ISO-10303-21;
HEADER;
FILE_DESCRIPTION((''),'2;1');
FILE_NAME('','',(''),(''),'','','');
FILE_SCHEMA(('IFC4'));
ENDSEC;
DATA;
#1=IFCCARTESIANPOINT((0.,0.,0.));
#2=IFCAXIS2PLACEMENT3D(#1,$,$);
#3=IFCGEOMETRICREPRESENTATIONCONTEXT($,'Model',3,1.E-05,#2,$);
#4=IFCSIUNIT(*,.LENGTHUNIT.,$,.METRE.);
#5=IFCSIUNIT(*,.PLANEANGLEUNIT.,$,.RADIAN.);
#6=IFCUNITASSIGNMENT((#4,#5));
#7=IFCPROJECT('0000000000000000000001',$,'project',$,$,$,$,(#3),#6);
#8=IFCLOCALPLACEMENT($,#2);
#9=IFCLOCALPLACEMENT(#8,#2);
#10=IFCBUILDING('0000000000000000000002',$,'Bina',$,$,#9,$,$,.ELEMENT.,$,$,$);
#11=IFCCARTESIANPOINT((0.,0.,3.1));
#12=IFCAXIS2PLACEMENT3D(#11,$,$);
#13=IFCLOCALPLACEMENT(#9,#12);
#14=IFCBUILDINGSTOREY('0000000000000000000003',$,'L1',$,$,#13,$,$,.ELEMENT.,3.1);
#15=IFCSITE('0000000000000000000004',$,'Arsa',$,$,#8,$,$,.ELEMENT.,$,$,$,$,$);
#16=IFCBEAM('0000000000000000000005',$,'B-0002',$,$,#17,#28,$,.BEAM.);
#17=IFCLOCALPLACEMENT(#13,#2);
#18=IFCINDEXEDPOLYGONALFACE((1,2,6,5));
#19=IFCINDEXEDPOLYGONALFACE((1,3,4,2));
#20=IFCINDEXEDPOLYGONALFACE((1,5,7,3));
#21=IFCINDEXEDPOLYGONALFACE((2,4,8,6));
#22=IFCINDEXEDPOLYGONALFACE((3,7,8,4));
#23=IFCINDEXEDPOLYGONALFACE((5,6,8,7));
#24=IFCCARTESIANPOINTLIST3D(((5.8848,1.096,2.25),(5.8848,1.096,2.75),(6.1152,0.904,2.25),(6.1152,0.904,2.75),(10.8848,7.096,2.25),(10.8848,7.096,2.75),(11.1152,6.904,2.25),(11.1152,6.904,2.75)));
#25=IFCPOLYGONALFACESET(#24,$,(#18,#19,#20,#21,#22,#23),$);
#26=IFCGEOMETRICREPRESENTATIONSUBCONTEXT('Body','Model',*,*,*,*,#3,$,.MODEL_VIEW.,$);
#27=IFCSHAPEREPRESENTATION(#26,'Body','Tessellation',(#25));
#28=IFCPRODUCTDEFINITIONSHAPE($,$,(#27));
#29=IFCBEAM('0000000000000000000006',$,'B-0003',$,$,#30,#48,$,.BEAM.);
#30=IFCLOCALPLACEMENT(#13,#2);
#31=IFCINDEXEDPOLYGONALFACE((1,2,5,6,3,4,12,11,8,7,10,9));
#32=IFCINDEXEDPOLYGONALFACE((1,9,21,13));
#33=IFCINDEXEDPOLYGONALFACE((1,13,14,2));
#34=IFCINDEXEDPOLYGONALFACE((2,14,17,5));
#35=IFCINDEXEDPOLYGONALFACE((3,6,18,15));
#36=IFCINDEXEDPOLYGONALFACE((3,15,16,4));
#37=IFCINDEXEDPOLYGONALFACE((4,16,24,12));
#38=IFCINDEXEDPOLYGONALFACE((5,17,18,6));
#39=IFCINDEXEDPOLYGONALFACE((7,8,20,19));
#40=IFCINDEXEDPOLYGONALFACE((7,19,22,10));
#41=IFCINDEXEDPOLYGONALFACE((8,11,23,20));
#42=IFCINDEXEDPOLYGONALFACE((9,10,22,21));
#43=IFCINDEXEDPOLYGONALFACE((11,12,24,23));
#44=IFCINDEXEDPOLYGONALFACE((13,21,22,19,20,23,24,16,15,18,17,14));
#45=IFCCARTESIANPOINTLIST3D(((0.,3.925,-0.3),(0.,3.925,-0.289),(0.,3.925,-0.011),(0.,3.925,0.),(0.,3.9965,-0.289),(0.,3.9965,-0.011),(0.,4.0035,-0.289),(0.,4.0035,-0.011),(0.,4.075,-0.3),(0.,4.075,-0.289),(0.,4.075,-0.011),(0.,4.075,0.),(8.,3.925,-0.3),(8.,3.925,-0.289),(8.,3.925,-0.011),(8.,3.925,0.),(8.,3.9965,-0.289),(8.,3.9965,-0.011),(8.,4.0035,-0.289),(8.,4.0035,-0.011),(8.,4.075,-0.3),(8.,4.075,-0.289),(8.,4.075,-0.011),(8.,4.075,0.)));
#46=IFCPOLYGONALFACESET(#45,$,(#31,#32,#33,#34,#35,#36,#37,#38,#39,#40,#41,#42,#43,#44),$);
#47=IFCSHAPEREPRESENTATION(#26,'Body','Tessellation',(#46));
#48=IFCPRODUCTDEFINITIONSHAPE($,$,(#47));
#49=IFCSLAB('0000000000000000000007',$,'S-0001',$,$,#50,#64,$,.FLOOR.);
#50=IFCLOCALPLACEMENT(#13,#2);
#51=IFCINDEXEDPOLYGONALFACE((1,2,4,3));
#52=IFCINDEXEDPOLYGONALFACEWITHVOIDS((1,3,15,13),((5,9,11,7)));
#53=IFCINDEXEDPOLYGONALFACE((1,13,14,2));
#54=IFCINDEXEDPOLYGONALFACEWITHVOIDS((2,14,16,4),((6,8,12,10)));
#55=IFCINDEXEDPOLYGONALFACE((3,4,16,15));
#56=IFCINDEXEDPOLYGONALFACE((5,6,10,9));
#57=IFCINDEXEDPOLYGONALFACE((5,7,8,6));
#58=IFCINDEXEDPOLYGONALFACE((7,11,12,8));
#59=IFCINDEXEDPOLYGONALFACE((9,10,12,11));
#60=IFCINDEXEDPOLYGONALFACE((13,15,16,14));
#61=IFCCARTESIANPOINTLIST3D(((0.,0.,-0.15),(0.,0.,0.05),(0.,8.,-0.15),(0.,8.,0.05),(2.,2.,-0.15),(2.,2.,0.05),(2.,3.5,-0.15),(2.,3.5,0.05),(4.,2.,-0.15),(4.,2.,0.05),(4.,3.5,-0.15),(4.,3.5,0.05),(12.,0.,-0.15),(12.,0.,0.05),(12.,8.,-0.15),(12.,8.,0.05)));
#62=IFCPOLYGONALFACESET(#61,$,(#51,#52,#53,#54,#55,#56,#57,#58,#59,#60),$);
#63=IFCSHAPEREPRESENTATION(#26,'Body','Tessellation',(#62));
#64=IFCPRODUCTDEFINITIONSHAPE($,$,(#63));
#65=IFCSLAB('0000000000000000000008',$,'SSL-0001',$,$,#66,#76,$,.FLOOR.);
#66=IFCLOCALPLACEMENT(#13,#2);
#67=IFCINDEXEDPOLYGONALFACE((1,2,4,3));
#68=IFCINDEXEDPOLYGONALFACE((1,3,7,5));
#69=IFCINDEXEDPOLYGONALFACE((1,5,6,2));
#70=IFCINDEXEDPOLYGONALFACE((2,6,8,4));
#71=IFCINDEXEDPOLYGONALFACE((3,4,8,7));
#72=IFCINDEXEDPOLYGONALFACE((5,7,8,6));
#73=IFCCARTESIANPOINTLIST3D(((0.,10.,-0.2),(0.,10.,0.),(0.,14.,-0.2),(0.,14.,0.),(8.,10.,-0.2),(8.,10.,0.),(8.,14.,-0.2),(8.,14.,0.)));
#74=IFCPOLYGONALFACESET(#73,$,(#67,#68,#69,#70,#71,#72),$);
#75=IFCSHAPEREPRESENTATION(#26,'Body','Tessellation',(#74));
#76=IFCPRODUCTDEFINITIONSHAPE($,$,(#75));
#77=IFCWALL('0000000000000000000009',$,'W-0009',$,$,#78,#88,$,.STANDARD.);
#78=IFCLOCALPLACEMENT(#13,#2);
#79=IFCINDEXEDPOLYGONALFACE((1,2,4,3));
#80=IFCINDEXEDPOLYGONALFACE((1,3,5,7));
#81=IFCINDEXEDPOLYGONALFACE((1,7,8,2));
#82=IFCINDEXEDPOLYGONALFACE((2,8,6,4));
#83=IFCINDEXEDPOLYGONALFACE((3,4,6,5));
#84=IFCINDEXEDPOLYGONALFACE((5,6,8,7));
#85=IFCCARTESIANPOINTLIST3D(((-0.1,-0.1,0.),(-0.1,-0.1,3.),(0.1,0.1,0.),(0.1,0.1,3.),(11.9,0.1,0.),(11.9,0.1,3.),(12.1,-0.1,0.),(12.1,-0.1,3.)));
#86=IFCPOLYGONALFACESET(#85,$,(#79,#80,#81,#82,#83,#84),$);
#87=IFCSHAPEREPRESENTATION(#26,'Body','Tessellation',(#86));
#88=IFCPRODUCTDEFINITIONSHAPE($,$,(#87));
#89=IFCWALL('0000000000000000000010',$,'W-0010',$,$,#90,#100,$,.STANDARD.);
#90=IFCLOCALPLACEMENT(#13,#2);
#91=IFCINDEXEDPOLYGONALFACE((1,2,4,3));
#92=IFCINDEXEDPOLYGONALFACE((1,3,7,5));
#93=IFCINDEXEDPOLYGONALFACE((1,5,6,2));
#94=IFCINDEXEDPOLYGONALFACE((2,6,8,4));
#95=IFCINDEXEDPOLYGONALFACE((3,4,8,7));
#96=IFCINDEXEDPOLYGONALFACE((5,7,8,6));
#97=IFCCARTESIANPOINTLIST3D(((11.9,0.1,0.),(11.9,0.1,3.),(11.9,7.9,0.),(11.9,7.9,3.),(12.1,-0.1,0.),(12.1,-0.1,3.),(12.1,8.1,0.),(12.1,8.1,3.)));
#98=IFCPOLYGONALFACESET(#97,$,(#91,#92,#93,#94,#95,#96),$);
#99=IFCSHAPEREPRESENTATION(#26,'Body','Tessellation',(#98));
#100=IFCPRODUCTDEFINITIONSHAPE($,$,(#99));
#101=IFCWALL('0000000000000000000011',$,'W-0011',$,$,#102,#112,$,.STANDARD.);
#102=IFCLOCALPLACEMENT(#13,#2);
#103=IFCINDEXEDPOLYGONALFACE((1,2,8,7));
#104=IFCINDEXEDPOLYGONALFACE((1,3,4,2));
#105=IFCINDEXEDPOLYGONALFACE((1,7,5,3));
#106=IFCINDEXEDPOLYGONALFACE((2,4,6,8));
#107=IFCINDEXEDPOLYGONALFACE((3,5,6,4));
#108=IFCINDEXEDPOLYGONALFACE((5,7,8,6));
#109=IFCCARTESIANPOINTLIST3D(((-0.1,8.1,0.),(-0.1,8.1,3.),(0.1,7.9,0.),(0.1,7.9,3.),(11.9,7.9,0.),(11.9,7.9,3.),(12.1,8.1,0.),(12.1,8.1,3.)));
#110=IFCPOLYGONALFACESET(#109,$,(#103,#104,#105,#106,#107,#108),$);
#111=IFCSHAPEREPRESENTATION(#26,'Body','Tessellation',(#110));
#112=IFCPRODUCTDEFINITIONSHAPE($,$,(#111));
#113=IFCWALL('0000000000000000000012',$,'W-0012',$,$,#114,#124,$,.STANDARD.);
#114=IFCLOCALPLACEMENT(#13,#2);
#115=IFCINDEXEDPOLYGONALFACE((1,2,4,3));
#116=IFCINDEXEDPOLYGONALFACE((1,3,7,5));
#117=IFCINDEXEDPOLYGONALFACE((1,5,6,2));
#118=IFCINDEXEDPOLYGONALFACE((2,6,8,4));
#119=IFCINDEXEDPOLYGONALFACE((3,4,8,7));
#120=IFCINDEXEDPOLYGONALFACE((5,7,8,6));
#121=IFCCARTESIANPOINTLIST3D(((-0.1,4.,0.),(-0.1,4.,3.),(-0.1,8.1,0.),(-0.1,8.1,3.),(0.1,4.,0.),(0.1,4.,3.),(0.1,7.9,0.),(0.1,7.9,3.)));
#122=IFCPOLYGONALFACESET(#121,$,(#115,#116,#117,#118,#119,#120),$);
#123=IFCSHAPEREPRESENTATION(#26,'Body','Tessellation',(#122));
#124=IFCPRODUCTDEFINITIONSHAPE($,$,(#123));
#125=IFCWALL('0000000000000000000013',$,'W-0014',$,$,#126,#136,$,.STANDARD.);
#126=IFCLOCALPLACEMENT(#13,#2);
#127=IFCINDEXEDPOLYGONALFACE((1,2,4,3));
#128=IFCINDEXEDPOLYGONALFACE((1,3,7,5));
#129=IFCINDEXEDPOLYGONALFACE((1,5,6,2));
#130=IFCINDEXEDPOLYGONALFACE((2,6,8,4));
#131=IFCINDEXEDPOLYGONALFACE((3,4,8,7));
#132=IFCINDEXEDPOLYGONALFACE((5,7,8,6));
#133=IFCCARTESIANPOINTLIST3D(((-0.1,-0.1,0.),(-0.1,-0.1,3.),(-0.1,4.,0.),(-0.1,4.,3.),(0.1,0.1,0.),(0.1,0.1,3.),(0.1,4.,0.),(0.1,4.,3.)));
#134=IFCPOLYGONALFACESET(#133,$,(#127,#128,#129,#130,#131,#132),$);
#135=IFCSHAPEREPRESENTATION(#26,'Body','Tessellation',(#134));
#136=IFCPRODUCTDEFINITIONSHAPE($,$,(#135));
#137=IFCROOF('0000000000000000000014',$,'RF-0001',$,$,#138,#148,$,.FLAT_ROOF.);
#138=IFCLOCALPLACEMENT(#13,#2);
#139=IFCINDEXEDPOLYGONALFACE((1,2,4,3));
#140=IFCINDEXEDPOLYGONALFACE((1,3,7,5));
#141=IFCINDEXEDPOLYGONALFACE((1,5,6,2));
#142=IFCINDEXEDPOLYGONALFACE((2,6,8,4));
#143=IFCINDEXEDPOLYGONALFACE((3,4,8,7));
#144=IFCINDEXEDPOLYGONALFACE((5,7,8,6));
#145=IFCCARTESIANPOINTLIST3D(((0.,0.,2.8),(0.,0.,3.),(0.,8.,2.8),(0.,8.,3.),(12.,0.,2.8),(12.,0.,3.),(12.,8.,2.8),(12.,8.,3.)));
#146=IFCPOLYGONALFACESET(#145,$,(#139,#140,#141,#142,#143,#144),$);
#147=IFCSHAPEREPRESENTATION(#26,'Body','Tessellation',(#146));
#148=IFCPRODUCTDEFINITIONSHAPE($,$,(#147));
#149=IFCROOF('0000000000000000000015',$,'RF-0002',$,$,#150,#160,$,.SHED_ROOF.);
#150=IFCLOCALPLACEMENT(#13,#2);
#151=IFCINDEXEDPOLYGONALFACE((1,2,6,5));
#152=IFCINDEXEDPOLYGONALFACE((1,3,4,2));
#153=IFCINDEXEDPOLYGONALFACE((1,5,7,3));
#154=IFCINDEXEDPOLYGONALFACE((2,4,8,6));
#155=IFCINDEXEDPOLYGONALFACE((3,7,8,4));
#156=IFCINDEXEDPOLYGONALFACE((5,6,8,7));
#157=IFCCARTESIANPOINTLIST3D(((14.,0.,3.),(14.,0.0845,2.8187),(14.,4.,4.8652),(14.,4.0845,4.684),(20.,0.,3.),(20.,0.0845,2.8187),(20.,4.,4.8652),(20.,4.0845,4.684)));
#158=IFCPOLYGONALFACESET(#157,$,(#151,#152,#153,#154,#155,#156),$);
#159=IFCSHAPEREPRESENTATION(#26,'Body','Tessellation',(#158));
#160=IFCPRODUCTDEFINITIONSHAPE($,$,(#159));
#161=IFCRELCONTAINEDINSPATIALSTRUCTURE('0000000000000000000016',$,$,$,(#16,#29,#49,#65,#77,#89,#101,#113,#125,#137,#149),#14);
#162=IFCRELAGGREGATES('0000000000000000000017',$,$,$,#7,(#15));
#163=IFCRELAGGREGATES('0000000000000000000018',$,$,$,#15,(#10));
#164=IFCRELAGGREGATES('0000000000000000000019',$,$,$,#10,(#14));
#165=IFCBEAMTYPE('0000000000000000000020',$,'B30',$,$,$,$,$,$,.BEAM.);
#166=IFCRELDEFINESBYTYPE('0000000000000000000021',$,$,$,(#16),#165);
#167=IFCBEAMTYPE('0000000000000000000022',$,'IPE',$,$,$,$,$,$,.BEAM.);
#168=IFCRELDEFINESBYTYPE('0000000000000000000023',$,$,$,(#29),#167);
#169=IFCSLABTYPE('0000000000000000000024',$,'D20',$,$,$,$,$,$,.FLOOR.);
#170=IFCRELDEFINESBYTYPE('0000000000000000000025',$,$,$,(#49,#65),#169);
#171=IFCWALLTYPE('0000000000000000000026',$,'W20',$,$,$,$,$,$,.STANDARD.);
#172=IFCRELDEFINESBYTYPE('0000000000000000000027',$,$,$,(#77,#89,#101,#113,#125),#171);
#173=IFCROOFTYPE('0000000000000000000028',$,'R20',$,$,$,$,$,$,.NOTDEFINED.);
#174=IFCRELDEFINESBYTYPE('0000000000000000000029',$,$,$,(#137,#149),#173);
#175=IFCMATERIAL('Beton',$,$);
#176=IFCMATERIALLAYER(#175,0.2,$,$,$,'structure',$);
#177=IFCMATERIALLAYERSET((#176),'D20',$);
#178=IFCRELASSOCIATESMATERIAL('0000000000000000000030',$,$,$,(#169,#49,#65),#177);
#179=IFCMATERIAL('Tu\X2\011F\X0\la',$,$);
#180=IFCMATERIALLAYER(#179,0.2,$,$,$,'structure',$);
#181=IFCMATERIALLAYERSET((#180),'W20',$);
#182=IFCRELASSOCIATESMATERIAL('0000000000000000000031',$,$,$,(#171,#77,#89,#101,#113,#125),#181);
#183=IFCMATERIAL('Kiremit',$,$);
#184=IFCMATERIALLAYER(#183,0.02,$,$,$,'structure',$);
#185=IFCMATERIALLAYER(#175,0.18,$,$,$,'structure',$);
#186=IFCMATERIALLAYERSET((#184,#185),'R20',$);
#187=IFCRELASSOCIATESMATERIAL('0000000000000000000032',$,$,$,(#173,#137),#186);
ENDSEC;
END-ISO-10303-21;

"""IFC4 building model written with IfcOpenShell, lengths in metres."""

from ifc_helpers import new_model, si_unit, frame, frame_2d, origin, origin_with_axes, place, context, subcontext, project, spatial, polyline, rectangle, i_section, outline, extrude, material, layer, layer_set, layer_usage, type_object, element, save


model = new_model("IFC4")

# Units and contexts
model_context = context("Model", 3, precision=1e-05, world=origin())
body_context = subcontext(model_context, "Body", "Model", "MODEL_VIEW")
ifc_project = project(units=[si_unit("LENGTHUNIT", "METRE"), si_unit("PLANEANGLEUNIT", "RADIAN")], contexts=[model_context])

# Site, building, storey
site_placement = place(None, origin())
site = spatial("IfcSite", under=ifc_project, at=site_placement, Name="Arsa", CompositionType="ELEMENT")
building_placement = place(site_placement, origin())
building = spatial("IfcBuilding", under=site, at=building_placement, Name="Bina", CompositionType="ELEMENT")
storey_placement = place(building_placement, frame((0.0, 0.0, 3.1)))
storey = spatial("IfcBuildingStorey", under=building, at=storey_placement, Name="L1", CompositionType="ELEMENT", Elevation=3.1)

# Beams
beam_type_1 = type_object("IfcBeamType", Name="B30", PredefinedType="BEAM")
beam_1_placement = place(storey_placement, origin())
element("IfcBeam", 1, at=beam_1_placement, inside=storey, type_object=beam_type_1, Name="B-0002", PredefinedType="BEAM", context=body_context, shape_type="SweptSolid", body=[
    extrude(rectangle(XDim=0.3, YDim=0.5, at=frame_2d((0.0, -0.25))), frame((6.0, 1.0, 2.75), z_axis=(0.640184, 0.768221, 0.0), x_axis=(-0.768221, 0.640184, 0.0)), (0.0, 0.0, 1.0), 7.8102),
])
beam_type_2 = type_object("IfcBeamType", Name="IPE", PredefinedType="BEAM")
beam_2_placement = place(storey_placement, origin())
element("IfcBeam", 2, at=beam_2_placement, inside=storey, type_object=beam_type_2, Name="B-0003", PredefinedType="BEAM", context=body_context, shape_type="SweptSolid", body=[
    extrude(i_section(OverallWidth=0.15, OverallDepth=0.3, WebThickness=0.007, FlangeThickness=0.011, at=frame_2d((0.0, -0.15))), frame((0.0, 4.0, 0.0), z_axis=(1.0, 0.0, 0.0), x_axis=(0.0, 1.0, 0.0)), (0.0, 0.0, 1.0), 8.0),
])

# Slabs
ifc_material_1 = material(Name="Beton")
ifc_layer_1 = layer(ifc_material_1, 0.2, Category="structure")
ifc_layer_set_1 = layer_set([ifc_layer_1], Name="D20")
ifc_layer_usage_1 = layer_usage(ifc_layer_set_1, "AXIS3", "NEGATIVE", 0.05)
slab_type = type_object("IfcSlabType", Name="D20", PredefinedType="FLOOR", material=ifc_layer_set_1)
slab_1_placement = place(storey_placement, origin())
element("IfcSlab", 3, at=slab_1_placement, inside=storey, type_object=slab_type, material=ifc_layer_usage_1, Name="S-0001", PredefinedType="FLOOR", context=body_context, shape_type="SweptSolid", body=[
    extrude(outline(polyline([(0.0, 0.0), (12.0, 0.0), (12.0, 8.0), (0.0, 8.0), (0.0, 0.0)]), holes=[polyline([(2.0, 2.0), (4.0, 2.0), (4.0, 3.5), (2.0, 3.5), (2.0, 2.0)])]), frame((0.0, 0.0, -0.15)), (0.0, 0.0, 1.0), 0.2),
])
ifc_layer_usage_2 = layer_usage(ifc_layer_set_1, "AXIS3", "NEGATIVE", 0.0)
slab_2_placement = place(storey_placement, origin())
element("IfcSlab", 4, at=slab_2_placement, inside=storey, type_object=slab_type, material=ifc_layer_usage_2, Name="SSL-0001", PredefinedType="FLOOR", context=body_context, shape_type="SweptSolid", body=[
    extrude(outline(polyline([(0.0, 10.0), (8.0, 10.0), (8.0, 14.0), (0.0, 14.0), (0.0, 10.0)])), frame((0.0, 0.0, -0.2)), (0.0, 0.0, 1.0), 0.2),
])

# Walls
ifc_material_2 = material(Name="Tuğla")
ifc_layer_2 = layer(ifc_material_2, 0.2, Category="structure")
ifc_layer_set_2 = layer_set([ifc_layer_2], Name="W20")
ifc_layer_usage_3 = layer_usage(ifc_layer_set_2, "AXIS2", "POSITIVE", -0.1)
wall_type = type_object("IfcWallType", Name="W20", PredefinedType="STANDARD", material=ifc_layer_set_2)
wall_1_placement = place(storey_placement, origin_with_axes())
element("IfcWall", 5, at=wall_1_placement, inside=storey, type_object=wall_type, material=ifc_layer_usage_3, Name="W-0009", PredefinedType="STANDARD", context=body_context, shape_type="SweptSolid", body=[
    extrude(outline(polyline([(0.1, 0.1), (11.9, 0.1), (12.1, -0.1), (-0.1, -0.1), (0.1, 0.1)])), origin(), (0.0, 0.0, 1.0), 3.0),
])
ifc_layer_usage_4 = layer_usage(ifc_layer_set_2, "AXIS2", "POSITIVE", -0.1)
wall_2_placement = place(storey_placement, frame((12.0, 0.0, 0.0), z_axis=(0.0, 0.0, 1.0), x_axis=(0.0, 1.0, 0.0)))
element("IfcWall", 6, at=wall_2_placement, inside=storey, type_object=wall_type, material=ifc_layer_usage_4, Name="W-0010", PredefinedType="STANDARD", context=body_context, shape_type="SweptSolid", body=[
    extrude(outline(polyline([(0.1, 0.1), (7.9, 0.1), (8.1, -0.1), (-0.1, -0.1), (0.1, 0.1)])), origin(), (0.0, 0.0, 1.0), 3.0),
])
ifc_layer_usage_5 = layer_usage(ifc_layer_set_2, "AXIS2", "POSITIVE", -0.1)
wall_3_placement = place(storey_placement, frame((12.0, 8.0, 0.0), z_axis=(0.0, 0.0, 1.0), x_axis=(-1.0, 0.0, 0.0)))
element("IfcWall", 7, at=wall_3_placement, inside=storey, type_object=wall_type, material=ifc_layer_usage_5, Name="W-0011", PredefinedType="STANDARD", context=body_context, shape_type="SweptSolid", body=[
    extrude(outline(polyline([(0.1, 0.1), (11.9, 0.1), (12.1, -0.1), (-0.1, -0.1), (0.1, 0.1)])), origin(), (0.0, 0.0, 1.0), 3.0),
])
ifc_layer_usage_6 = layer_usage(ifc_layer_set_2, "AXIS2", "POSITIVE", -0.1)
wall_4_placement = place(storey_placement, frame((0.0, 8.0, 0.0), z_axis=(0.0, 0.0, 1.0), x_axis=(0.0, -1.0, 0.0)))
element("IfcWall", 8, at=wall_4_placement, inside=storey, type_object=wall_type, material=ifc_layer_usage_6, Name="W-0012", PredefinedType="STANDARD", context=body_context, shape_type="SweptSolid", body=[
    extrude(outline(polyline([(0.1, 0.1), (4.0, 0.1), (4.0, -0.1), (-0.1, -0.1), (0.1, 0.1)])), origin(), (0.0, 0.0, 1.0), 3.0),
])
ifc_layer_usage_7 = layer_usage(ifc_layer_set_2, "AXIS2", "POSITIVE", -0.1)
wall_5_placement = place(storey_placement, frame((0.0, 4.0, 0.0), z_axis=(0.0, 0.0, 1.0), x_axis=(0.0, -1.0, 0.0)))
element("IfcWall", 9, at=wall_5_placement, inside=storey, type_object=wall_type, material=ifc_layer_usage_7, Name="W-0014", PredefinedType="STANDARD", context=body_context, shape_type="SweptSolid", body=[
    extrude(outline(polyline([(0.0, 0.1), (3.9, 0.1), (4.1, -0.1), (0.0, -0.1), (0.0, 0.1)])), origin(), (0.0, 0.0, 1.0), 3.0),
])

# Roofs
ifc_material_3 = material(Name="Kiremit")
ifc_layer_3 = layer(ifc_material_3, 0.02, Category="structure")
ifc_layer_4 = layer(ifc_material_1, 0.18, Category="structure")
ifc_layer_set_3 = layer_set([ifc_layer_3, ifc_layer_4], Name="R20")
ifc_layer_usage_8 = layer_usage(ifc_layer_set_3, "AXIS3", "NEGATIVE", 3.0)
roof_type = type_object("IfcRoofType", Name="R20", PredefinedType="NOTDEFINED", material=ifc_layer_set_3)
roof_1_placement = place(storey_placement, origin())
element("IfcRoof", 10, at=roof_1_placement, inside=storey, type_object=roof_type, material=ifc_layer_usage_8, Name="RF-0001", PredefinedType="FLAT_ROOF", context=body_context, shape_type="SweptSolid", body=[
    extrude(outline(polyline([(0.0, 0.0), (12.0, 0.0), (12.0, 8.0), (0.0, 8.0), (0.0, 0.0)])), frame((0.0, 0.0, 2.8)), (0.0, 0.0, 1.0), 0.2),
])
roof_2_placement = place(storey_placement, origin())
element("IfcRoof", 11, at=roof_2_placement, inside=storey, type_object=roof_type, Name="RF-0002", PredefinedType="SHED_ROOF", context=body_context, shape_type="SweptSolid", body=[
    extrude(outline(polyline([(14.0, 0.0), (20.0, 0.0), (20.0, 4.4135), (14.0, 4.4135), (14.0, 0.0)])), frame((0.0, 0.0845, 2.8187), z_axis=(0.0, -0.422618, 0.906308), x_axis=(1.0, 0.0, 0.0)), (0.0, 0.0, 1.0), 0.2),
])

save(model, "model.ifc")
